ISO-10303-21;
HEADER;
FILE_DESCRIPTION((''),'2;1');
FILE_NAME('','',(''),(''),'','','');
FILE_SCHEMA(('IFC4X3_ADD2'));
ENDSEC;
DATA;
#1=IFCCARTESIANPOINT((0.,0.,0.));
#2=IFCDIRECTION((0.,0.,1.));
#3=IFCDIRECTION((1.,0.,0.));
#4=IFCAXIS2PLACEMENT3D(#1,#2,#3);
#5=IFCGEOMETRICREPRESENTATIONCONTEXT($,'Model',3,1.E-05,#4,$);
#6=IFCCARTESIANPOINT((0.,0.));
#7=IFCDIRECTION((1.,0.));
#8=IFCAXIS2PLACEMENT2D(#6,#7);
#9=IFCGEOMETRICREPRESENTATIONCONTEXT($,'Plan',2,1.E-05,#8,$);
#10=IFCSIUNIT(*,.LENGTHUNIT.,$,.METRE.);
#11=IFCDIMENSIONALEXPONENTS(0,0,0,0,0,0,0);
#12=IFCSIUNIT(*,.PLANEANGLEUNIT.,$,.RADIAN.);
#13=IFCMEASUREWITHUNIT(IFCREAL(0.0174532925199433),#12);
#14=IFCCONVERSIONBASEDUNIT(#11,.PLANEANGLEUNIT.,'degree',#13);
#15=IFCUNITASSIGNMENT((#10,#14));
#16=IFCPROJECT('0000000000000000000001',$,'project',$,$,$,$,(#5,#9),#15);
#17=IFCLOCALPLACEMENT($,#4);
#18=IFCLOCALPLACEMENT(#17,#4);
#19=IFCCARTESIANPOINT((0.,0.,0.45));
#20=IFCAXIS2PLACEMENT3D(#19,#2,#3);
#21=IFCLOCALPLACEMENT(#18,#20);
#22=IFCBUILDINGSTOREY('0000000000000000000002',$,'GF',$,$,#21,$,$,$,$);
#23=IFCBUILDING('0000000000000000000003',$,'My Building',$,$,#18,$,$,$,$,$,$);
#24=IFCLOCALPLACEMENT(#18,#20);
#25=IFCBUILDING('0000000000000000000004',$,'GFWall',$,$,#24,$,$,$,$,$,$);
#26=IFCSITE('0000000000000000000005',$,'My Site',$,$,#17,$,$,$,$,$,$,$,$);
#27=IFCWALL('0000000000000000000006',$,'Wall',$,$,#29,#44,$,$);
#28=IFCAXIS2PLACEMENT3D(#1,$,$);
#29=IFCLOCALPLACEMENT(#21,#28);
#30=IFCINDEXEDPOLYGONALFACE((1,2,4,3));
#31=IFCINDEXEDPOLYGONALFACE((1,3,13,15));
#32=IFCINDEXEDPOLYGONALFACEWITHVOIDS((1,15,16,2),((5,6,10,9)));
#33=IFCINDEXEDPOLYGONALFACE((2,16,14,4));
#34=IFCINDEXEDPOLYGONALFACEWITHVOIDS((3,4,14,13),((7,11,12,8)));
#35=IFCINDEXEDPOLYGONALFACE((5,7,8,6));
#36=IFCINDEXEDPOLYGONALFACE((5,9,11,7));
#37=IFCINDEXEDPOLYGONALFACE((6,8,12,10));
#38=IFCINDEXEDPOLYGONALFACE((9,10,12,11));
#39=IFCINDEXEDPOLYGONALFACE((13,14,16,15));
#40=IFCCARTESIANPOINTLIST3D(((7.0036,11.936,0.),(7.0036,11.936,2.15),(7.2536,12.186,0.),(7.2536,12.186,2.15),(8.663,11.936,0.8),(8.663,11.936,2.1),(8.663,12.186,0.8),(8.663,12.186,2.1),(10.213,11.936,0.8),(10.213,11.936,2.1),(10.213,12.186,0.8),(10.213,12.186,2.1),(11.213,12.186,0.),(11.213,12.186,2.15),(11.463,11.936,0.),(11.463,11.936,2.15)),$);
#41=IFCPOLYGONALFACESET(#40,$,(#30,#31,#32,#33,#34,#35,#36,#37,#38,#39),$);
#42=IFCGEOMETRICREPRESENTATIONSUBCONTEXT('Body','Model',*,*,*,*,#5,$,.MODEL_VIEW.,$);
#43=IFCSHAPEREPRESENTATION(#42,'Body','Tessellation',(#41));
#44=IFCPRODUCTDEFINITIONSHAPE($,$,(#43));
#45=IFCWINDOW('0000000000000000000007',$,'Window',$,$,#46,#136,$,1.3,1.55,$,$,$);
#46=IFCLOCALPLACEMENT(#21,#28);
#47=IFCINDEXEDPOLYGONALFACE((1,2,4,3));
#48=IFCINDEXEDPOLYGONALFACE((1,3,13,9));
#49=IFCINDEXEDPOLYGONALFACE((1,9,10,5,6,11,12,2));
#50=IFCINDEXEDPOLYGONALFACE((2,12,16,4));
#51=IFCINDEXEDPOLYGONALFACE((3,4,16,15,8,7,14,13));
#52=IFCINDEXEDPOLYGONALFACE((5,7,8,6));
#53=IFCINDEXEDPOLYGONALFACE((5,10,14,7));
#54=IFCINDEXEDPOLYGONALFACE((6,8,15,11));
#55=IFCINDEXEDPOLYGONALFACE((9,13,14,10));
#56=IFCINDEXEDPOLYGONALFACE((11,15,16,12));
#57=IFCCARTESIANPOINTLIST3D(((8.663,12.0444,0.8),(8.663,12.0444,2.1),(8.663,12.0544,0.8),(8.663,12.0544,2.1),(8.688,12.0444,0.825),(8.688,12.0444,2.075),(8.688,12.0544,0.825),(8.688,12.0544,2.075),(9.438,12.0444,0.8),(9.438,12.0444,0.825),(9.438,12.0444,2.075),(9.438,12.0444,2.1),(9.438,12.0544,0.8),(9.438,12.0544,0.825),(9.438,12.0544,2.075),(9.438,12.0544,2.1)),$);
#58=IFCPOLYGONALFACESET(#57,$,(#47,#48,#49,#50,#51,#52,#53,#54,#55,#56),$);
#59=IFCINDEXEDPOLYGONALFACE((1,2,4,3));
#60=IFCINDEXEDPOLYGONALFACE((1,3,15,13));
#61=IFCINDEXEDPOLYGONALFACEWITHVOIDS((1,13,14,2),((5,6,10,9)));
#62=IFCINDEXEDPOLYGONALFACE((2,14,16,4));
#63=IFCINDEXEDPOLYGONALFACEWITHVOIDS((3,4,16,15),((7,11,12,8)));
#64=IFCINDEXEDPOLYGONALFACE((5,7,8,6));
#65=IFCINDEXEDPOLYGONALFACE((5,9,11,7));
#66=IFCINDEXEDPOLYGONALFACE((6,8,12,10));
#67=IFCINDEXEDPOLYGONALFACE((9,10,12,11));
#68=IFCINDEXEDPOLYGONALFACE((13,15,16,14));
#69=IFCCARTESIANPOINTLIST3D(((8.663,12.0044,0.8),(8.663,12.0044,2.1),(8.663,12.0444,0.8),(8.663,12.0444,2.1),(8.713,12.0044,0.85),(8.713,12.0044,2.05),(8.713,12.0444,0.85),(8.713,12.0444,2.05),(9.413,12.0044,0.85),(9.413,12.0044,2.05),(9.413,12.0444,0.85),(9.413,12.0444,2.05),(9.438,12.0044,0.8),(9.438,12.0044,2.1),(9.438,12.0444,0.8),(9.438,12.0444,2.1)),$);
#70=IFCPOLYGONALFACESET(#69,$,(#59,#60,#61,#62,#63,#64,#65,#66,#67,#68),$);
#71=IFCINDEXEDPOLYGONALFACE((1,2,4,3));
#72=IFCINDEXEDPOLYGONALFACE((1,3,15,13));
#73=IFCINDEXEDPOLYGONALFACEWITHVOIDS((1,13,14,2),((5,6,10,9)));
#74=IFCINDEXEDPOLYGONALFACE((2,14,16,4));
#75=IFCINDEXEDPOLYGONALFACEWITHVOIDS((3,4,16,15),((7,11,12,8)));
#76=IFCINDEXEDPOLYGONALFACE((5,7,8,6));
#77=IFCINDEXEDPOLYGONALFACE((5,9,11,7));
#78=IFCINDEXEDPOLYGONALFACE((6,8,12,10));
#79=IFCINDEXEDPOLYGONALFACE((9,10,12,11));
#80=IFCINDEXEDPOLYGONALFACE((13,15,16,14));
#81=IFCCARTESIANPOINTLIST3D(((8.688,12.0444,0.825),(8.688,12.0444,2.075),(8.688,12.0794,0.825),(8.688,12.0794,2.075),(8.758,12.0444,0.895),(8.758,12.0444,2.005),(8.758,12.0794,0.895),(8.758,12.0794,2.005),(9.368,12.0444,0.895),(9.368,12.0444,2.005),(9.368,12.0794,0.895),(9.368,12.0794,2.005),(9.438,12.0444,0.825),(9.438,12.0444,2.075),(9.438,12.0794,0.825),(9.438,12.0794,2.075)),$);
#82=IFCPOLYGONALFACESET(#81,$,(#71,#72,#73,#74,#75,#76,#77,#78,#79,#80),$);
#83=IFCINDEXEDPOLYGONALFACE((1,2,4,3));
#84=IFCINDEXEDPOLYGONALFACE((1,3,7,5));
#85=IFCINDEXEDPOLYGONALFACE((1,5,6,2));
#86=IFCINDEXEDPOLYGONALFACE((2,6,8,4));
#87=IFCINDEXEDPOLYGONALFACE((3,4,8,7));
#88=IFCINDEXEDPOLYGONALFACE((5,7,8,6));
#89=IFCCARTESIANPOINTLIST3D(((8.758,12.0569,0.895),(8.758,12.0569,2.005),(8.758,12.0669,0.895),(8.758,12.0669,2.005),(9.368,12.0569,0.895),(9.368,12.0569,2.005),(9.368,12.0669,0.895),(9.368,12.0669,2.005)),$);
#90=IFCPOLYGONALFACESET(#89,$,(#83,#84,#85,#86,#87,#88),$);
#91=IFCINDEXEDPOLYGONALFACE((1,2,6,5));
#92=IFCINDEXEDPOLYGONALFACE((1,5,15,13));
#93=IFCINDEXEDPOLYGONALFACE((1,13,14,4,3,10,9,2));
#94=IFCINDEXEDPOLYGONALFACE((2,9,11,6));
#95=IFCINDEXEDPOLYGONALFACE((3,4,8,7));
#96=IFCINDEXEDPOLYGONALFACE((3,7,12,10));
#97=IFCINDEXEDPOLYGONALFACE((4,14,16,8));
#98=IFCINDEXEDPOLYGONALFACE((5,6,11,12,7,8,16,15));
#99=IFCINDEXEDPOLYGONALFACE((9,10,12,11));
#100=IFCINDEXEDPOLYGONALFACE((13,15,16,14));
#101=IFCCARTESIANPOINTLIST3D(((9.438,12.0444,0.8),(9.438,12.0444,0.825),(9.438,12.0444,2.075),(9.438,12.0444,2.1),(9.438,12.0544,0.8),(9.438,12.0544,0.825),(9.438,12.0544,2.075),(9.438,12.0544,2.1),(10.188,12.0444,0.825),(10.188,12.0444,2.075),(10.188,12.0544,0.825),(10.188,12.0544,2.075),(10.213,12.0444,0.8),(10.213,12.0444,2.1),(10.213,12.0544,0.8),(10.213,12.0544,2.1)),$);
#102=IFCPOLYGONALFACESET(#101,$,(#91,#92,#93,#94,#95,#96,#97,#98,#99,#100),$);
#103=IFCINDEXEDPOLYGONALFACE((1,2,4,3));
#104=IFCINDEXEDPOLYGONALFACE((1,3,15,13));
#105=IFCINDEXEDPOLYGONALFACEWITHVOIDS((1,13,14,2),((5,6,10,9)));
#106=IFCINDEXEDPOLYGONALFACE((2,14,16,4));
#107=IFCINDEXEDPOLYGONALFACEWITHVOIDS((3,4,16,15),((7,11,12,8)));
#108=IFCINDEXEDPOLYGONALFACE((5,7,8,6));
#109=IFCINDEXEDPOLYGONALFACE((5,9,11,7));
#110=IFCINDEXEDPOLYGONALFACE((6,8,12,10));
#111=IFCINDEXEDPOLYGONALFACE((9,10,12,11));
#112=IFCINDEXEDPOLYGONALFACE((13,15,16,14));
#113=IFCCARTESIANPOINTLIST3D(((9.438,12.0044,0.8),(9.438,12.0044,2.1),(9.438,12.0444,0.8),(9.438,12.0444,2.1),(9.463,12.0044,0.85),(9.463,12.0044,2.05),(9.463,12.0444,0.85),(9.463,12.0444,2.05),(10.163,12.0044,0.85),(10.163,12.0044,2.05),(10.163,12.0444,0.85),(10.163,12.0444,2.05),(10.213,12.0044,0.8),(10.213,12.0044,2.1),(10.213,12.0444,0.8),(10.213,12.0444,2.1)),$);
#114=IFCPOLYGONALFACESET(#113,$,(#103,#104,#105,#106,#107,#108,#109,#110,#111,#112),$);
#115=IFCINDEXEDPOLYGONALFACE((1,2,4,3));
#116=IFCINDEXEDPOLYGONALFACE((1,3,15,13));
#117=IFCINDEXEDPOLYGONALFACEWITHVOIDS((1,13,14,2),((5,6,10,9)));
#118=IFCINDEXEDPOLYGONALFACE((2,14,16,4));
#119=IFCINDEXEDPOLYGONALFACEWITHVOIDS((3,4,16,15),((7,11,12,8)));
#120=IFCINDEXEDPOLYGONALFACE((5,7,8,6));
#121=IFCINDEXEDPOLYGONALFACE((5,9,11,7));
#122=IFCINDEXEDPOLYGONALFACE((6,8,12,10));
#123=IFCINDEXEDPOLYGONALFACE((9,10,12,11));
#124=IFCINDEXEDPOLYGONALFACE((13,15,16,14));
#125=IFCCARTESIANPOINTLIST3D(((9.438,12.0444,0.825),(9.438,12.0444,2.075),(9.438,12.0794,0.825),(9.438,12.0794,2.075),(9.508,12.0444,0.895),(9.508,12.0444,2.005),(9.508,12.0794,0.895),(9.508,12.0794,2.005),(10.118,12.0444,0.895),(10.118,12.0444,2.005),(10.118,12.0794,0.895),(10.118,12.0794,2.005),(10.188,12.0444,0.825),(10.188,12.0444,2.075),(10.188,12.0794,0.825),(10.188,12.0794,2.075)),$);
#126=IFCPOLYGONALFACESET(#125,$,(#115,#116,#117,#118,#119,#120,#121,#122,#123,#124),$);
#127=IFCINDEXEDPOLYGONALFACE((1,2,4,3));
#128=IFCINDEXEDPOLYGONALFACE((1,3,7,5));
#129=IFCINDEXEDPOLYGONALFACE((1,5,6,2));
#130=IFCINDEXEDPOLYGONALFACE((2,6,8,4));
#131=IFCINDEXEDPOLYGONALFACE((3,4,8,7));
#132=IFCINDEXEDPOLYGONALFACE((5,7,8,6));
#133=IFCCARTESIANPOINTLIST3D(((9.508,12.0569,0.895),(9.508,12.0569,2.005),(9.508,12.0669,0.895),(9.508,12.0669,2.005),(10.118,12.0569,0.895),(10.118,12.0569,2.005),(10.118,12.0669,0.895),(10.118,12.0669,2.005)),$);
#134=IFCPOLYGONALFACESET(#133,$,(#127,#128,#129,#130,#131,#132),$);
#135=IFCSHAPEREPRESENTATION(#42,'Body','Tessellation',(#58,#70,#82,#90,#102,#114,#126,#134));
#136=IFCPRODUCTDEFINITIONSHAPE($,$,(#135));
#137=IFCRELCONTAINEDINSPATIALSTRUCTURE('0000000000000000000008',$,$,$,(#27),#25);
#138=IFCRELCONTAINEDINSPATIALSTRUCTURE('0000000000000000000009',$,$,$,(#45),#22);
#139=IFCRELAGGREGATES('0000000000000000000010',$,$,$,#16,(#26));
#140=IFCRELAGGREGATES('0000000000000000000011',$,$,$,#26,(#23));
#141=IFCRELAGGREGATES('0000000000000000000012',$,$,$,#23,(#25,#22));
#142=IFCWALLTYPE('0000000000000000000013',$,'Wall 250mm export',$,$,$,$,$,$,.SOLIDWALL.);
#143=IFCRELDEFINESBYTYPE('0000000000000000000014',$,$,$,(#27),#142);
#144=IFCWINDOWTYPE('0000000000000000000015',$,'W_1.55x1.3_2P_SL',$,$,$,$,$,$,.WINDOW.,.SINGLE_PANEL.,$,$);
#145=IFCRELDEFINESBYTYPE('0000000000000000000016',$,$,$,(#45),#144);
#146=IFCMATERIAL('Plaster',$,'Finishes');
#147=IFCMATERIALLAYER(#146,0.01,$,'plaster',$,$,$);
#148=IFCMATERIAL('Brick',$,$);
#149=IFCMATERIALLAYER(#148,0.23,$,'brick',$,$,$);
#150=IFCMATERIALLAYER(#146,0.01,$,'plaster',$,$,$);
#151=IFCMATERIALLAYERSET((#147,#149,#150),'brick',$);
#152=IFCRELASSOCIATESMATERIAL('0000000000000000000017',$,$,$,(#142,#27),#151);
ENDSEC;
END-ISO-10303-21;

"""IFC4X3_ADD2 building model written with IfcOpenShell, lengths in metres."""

from ifc_helpers import new_model, entity, si_unit, converted_unit, frame, origin_with_axes, origin_2d_with_axis, place, context, subcontext, project, spatial, line, indexed_curve, outline, extrude, shape, source, transform, mapped, material, layer, layer_set, layer_usage, type_object, type_shapes, element, fill, save


model = new_model("IFC4X3_ADD2")

# Units and contexts
model_context = context("Model", 3, precision=1e-05, world=origin_with_axes())
plan_context = context("Plan", 2, precision=1e-05, world=origin_2d_with_axis())
body_context_1 = subcontext(model_context, "Body", "Model", "MODEL_VIEW")
body_context_2 = subcontext(plan_context, "Body", "Plan", "PLAN_VIEW")
ifc_project = project(units=[si_unit("LENGTHUNIT", "METRE"), converted_unit("PLANEANGLEUNIT", "degree", entity("IfcReal", 0.0174532925199433), si_unit("PLANEANGLEUNIT", "RADIAN"), dimensions=[0, 0, 0, 0, 0, 0, 0])], contexts=[model_context, plan_context])

# Site, buildings
site_placement = place(None, origin_with_axes())
site = spatial("IfcSite", under=ifc_project, at=site_placement, Name="My Site")
building_1_placement = place(site_placement, origin_with_axes())
building_1 = spatial("IfcBuilding", under=site, at=building_1_placement, Name="My Building")
building_2_placement = place(building_1_placement, frame((0.0, 0.0, 0.45), z_axis=(0.0, 0.0, 1.0), x_axis=(1.0, 0.0, 0.0)))
building_2 = spatial("IfcBuilding", under=building_1, at=building_2_placement, Name="GFWall")

# Shared definitions
ifc_material_1 = material(Name="Plaster", Category="Finishes")
ifc_layer_1 = layer(ifc_material_1, 0.01, Name="plaster")
ifc_material_2 = material(Name="Brick")
ifc_layer_2 = layer(ifc_material_2, 0.23, Name="brick")
ifc_layer_3 = layer(ifc_material_1, 0.01, Name="plaster")
ifc_layer_set = layer_set([ifc_layer_1, ifc_layer_2, ifc_layer_3], Name="brick")
wall_type = type_object("IfcWallType", Name="Wall 250mm export", PredefinedType="SOLIDWALL", material=ifc_layer_set)

# Shared definitions
storey_placement = place(building_1_placement, frame((0.0, 0.0, 0.45), z_axis=(0.0, 0.0, 1.0), x_axis=(1.0, 0.0, 0.0)))
storey = spatial("IfcBuildingStorey", under=building_1, at=storey_placement, Name="GF")

# Wall, opening, window
shared_shape_1 = source(origin_with_axes(), body_context_1, "Body", "SweptSolid", [
    extrude(outline(indexed_curve([(0.0, 0.0), (1.55, 0.0), (1.55, 1.3), (0.0, 1.3)], segments=[line(1, 2, 3, 4, 1)])), frame((0.0, -0.6, 0.0), z_axis=(0.0, -1.0, 0.0), x_axis=(1.0, 0.0, 0.0)), (0.0, 0.0, -1.0), 1.2),
])
window_type_1 = type_object("IfcWindowType", Name="W_1.55x1.3_2P_SL", PartitioningType="SINGLE_PANEL", PredefinedType="WINDOW")
shared_shape_2 = source(origin_with_axes(), body_context_1, "Body", "SweptSolid", [
    extrude(outline(indexed_curve([(0.775, 0.0), (0.0, 0.0), (0.0, 1.3), (0.775, 1.3), (0.775, 1.275), (0.025, 1.275), (0.025, 0.025), (0.775, 0.025)], segments=[line(1, 2, 3, 4, 5, 6, 7, 8, 1)])), frame((0.0, 0.09, 0.0), z_axis=(0.0, -1.0, 0.0), x_axis=(1.0, 0.0, 0.0)), (0.0, 0.0, -1.0), 0.01),
    extrude(outline(indexed_curve([(0.0, 0.0), (0.775, 0.0), (0.775, 1.3), (0.0, 1.3)], segments=[line(1, 2, 3, 4, 1)]), holes=[indexed_curve([(0.05, 0.05), (0.75, 0.05), (0.75, 1.25), (0.05, 1.25)], segments=[line(1, 2, 3, 4, 1)])]), frame((0.0, 0.05, 0.0), z_axis=(0.0, -1.0, 0.0), x_axis=(1.0, 0.0, 0.0)), (0.0, 0.0, -1.0), 0.04),
    extrude(outline(indexed_curve([(0.0, 0.0), (0.75, 0.0), (0.75, 1.25), (0.0, 1.25)], segments=[line(1, 2, 3, 4, 1)]), holes=[indexed_curve([(0.07, 0.07), (0.68, 0.07), (0.68, 1.18), (0.07, 1.18)], segments=[line(1, 2, 3, 4, 1)])]), frame((0.025, 0.09, 0.025), z_axis=(0.0, -1.0, 0.0), x_axis=(1.0, 0.0, 0.0)), (0.0, 0.0, -1.0), 0.035),
    extrude(outline(indexed_curve([(0.07, 0.07), (0.68, 0.07), (0.68, 1.18), (0.07, 1.18)], segments=[line(1, 2, 3, 4, 1)])), frame((0.025, 0.1025, 0.025), z_axis=(0.0, -1.0, 0.0), x_axis=(1.0, 0.0, 0.0)), (0.0, 0.0, -1.0), 0.01),
    extrude(outline(indexed_curve([(0.0, 1.3), (0.775, 1.3), (0.775, 0.0), (0.0, 0.0), (0.0, 0.025), (0.75, 0.025), (0.75, 1.275), (0.0, 1.275)], segments=[line(1, 2, 3, 4, 5, 6, 7, 8, 1)])), frame((0.775, 0.09, 0.0), z_axis=(0.0, -1.0, 0.0), x_axis=(1.0, 0.0, 0.0)), (0.0, 0.0, -1.0), 0.01),
    extrude(outline(indexed_curve([(0.0, 0.0), (0.775, 0.0), (0.775, 1.3), (0.0, 1.3)], segments=[line(1, 2, 3, 4, 1)]), holes=[indexed_curve([(0.025, 0.05), (0.725, 0.05), (0.725, 1.25), (0.025, 1.25)], segments=[line(1, 2, 3, 4, 1)])]), frame((0.775, 0.05, 0.0), z_axis=(0.0, -1.0, 0.0), x_axis=(1.0, 0.0, 0.0)), (0.0, 0.0, -1.0), 0.04),
    extrude(outline(indexed_curve([(0.0, 0.0), (0.75, 0.0), (0.75, 1.25), (0.0, 1.25)], segments=[line(1, 2, 3, 4, 1)]), holes=[indexed_curve([(0.07, 0.07), (0.68, 0.07), (0.68, 1.18), (0.07, 1.18)], segments=[line(1, 2, 3, 4, 1)])]), frame((0.775, 0.09, 0.025), z_axis=(0.0, -1.0, 0.0), x_axis=(1.0, 0.0, 0.0)), (0.0, 0.0, -1.0), 0.035),
    extrude(outline(indexed_curve([(0.07, 0.07), (0.68, 0.07), (0.68, 1.18), (0.07, 1.18)], segments=[line(1, 2, 3, 4, 1)])), frame((0.775, 0.1025, 0.025), z_axis=(0.0, -1.0, 0.0), x_axis=(1.0, 0.0, 0.0)), (0.0, 0.0, -1.0), 0.01),
])
shared_shape_3 = source(origin_with_axes(), body_context_2, "Body", "Curve2D", [
    entity("IfcIndexedPolyCurve", entity("IfcCartesianPointList2D", [[0.05, 0.05], [0.75, 0.05]])),
    entity("IfcIndexedPolyCurve", entity("IfcCartesianPointList2D", [[0.0, 0.1], [0.025, 0.1], [0.025, 0.09], [0.05, 0.09], [0.05, 0.05], [0.0, 0.05]]), [entity("IfcLineIndex", [1, 2, 3, 4, 5, 6, 1])]),
    entity("IfcIndexedPolyCurve", entity("IfcCartesianPointList2D", [[0.775, 0.1], [0.775, 0.1], [0.775, 0.09], [0.75, 0.09], [0.75, 0.05], [0.775, 0.05]])),
    entity("IfcIndexedPolyCurve", entity("IfcCartesianPointList2D", [[0.025, 0.09], [0.095, 0.09], [0.095, 0.125], [0.025, 0.125]]), [entity("IfcLineIndex", [1, 2, 3, 4, 1])]),
    entity("IfcIndexedPolyCurve", entity("IfcCartesianPointList2D", [[0.775, 0.09], [0.705, 0.09], [0.705, 0.125], [0.775, 0.125]]), [entity("IfcLineIndex", [1, 2, 3, 4, 1])]),
    entity("IfcIndexedPolyCurve", entity("IfcCartesianPointList2D", [[0.095, 0.09], [0.705, 0.09]])),
    entity("IfcIndexedPolyCurve", entity("IfcCartesianPointList2D", [[0.095, 0.125], [0.705, 0.125]])),
    entity("IfcIndexedPolyCurve", entity("IfcCartesianPointList2D", [[0.095, 0.1075], [0.705, 0.1075]])),
    entity("IfcIndexedPolyCurve", entity("IfcCartesianPointList2D", [[0.8, 0.05], [1.5, 0.05]])),
    entity("IfcIndexedPolyCurve", entity("IfcCartesianPointList2D", [[0.775, 0.1], [0.775, 0.1], [0.775, 0.09], [0.8, 0.09], [0.8, 0.05], [0.775, 0.05]])),
    entity("IfcIndexedPolyCurve", entity("IfcCartesianPointList2D", [[1.55, 0.1], [1.525, 0.1], [1.525, 0.09], [1.5, 0.09], [1.5, 0.05], [1.55, 0.05]]), [entity("IfcLineIndex", [1, 2, 3, 4, 5, 6, 1])]),
    entity("IfcIndexedPolyCurve", entity("IfcCartesianPointList2D", [[0.775, 0.09], [0.845, 0.09], [0.845, 0.125], [0.775, 0.125]]), [entity("IfcLineIndex", [1, 2, 3, 4, 1])]),
    entity("IfcIndexedPolyCurve", entity("IfcCartesianPointList2D", [[1.525, 0.09], [1.455, 0.09], [1.455, 0.125], [1.525, 0.125]]), [entity("IfcLineIndex", [1, 2, 3, 4, 1])]),
    entity("IfcIndexedPolyCurve", entity("IfcCartesianPointList2D", [[0.845, 0.09], [1.455, 0.09]])),
    entity("IfcIndexedPolyCurve", entity("IfcCartesianPointList2D", [[0.845, 0.125], [1.455, 0.125]])),
    entity("IfcIndexedPolyCurve", entity("IfcCartesianPointList2D", [[0.845, 0.1075], [1.455, 0.1075]])),
])
type_shapes(window_type_1, [shared_shape_2, shared_shape_3])
ifc_layer_usage_1 = layer_usage(ifc_layer_set, "AXIS2", "POSITIVE", 0.0)
wall_1_placement = place(building_2_placement, frame((7.2536, 11.936, 0.0), z_axis=(0.0, 0.0, 1.0), x_axis=(1.0, 0.0, 0.0)))
wall_1 = element("IfcWall", 1, at=wall_1_placement, inside=building_2, type_object=wall_type, material=ifc_layer_usage_1, Name="Wall", context=body_context_1, shape_type="SweptSolid", body=[
    extrude(outline(indexed_curve([(-0.25, 0.0), (0.0, 0.25), (3.9594, 0.25), (4.2094, 0.0)], segments=[line(1, 2, 3, 4, 1)])), origin_with_axes(), (0.0, 0.0, 1.0), 2.15),
])
opening_1_placement = place(wall_1_placement, frame((1.4094, 0.0184, 0.8), z_axis=(0.0, 0.0, 1.0), x_axis=(1.0, 0.0, 0.0)))
opening_1 = element("IfcOpeningElement", 2, at=opening_1_placement, cuts=wall_1, PredefinedType="OPENING", context=body_context_1, shape_type="MappedRepresentation", body=[
    mapped(shared_shape_1, transform((0.0, 0.0, 0.0), x_axis=(1.0, 0.0, 0.0), y_axis=(0.0, 1.0, 0.0), z_axis=(0.0, 0.0, 1.0), scale=1.0)),
])
window_1_placement = place(opening_1_placement, origin_with_axes())
window_1 = element("IfcWindow", 3, at=window_1_placement, inside=storey, type_object=window_type_1, Name="Window", OverallHeight=1.3, OverallWidth=1.55, shapes=[
    shape(body_context_1, "Body", "MappedRepresentation", [mapped(shared_shape_2, transform((0.0, 0.0, 0.0), x_axis=(1.0, 0.0, 0.0), y_axis=(0.0, 1.0, 0.0), z_axis=(0.0, 0.0, 1.0), scale=1.0))]),
    shape(body_context_2, "Body", "MappedRepresentation", [mapped(shared_shape_3, transform((0.0, 0.0, 0.0), x_axis=(1.0, 0.0, 0.0), y_axis=(0.0, 1.0, 0.0), z_axis=(0.0, 0.0, 1.0), scale=1.0))]),
])
fill(opening_1, window_1)

save(model, "model.ifc")
